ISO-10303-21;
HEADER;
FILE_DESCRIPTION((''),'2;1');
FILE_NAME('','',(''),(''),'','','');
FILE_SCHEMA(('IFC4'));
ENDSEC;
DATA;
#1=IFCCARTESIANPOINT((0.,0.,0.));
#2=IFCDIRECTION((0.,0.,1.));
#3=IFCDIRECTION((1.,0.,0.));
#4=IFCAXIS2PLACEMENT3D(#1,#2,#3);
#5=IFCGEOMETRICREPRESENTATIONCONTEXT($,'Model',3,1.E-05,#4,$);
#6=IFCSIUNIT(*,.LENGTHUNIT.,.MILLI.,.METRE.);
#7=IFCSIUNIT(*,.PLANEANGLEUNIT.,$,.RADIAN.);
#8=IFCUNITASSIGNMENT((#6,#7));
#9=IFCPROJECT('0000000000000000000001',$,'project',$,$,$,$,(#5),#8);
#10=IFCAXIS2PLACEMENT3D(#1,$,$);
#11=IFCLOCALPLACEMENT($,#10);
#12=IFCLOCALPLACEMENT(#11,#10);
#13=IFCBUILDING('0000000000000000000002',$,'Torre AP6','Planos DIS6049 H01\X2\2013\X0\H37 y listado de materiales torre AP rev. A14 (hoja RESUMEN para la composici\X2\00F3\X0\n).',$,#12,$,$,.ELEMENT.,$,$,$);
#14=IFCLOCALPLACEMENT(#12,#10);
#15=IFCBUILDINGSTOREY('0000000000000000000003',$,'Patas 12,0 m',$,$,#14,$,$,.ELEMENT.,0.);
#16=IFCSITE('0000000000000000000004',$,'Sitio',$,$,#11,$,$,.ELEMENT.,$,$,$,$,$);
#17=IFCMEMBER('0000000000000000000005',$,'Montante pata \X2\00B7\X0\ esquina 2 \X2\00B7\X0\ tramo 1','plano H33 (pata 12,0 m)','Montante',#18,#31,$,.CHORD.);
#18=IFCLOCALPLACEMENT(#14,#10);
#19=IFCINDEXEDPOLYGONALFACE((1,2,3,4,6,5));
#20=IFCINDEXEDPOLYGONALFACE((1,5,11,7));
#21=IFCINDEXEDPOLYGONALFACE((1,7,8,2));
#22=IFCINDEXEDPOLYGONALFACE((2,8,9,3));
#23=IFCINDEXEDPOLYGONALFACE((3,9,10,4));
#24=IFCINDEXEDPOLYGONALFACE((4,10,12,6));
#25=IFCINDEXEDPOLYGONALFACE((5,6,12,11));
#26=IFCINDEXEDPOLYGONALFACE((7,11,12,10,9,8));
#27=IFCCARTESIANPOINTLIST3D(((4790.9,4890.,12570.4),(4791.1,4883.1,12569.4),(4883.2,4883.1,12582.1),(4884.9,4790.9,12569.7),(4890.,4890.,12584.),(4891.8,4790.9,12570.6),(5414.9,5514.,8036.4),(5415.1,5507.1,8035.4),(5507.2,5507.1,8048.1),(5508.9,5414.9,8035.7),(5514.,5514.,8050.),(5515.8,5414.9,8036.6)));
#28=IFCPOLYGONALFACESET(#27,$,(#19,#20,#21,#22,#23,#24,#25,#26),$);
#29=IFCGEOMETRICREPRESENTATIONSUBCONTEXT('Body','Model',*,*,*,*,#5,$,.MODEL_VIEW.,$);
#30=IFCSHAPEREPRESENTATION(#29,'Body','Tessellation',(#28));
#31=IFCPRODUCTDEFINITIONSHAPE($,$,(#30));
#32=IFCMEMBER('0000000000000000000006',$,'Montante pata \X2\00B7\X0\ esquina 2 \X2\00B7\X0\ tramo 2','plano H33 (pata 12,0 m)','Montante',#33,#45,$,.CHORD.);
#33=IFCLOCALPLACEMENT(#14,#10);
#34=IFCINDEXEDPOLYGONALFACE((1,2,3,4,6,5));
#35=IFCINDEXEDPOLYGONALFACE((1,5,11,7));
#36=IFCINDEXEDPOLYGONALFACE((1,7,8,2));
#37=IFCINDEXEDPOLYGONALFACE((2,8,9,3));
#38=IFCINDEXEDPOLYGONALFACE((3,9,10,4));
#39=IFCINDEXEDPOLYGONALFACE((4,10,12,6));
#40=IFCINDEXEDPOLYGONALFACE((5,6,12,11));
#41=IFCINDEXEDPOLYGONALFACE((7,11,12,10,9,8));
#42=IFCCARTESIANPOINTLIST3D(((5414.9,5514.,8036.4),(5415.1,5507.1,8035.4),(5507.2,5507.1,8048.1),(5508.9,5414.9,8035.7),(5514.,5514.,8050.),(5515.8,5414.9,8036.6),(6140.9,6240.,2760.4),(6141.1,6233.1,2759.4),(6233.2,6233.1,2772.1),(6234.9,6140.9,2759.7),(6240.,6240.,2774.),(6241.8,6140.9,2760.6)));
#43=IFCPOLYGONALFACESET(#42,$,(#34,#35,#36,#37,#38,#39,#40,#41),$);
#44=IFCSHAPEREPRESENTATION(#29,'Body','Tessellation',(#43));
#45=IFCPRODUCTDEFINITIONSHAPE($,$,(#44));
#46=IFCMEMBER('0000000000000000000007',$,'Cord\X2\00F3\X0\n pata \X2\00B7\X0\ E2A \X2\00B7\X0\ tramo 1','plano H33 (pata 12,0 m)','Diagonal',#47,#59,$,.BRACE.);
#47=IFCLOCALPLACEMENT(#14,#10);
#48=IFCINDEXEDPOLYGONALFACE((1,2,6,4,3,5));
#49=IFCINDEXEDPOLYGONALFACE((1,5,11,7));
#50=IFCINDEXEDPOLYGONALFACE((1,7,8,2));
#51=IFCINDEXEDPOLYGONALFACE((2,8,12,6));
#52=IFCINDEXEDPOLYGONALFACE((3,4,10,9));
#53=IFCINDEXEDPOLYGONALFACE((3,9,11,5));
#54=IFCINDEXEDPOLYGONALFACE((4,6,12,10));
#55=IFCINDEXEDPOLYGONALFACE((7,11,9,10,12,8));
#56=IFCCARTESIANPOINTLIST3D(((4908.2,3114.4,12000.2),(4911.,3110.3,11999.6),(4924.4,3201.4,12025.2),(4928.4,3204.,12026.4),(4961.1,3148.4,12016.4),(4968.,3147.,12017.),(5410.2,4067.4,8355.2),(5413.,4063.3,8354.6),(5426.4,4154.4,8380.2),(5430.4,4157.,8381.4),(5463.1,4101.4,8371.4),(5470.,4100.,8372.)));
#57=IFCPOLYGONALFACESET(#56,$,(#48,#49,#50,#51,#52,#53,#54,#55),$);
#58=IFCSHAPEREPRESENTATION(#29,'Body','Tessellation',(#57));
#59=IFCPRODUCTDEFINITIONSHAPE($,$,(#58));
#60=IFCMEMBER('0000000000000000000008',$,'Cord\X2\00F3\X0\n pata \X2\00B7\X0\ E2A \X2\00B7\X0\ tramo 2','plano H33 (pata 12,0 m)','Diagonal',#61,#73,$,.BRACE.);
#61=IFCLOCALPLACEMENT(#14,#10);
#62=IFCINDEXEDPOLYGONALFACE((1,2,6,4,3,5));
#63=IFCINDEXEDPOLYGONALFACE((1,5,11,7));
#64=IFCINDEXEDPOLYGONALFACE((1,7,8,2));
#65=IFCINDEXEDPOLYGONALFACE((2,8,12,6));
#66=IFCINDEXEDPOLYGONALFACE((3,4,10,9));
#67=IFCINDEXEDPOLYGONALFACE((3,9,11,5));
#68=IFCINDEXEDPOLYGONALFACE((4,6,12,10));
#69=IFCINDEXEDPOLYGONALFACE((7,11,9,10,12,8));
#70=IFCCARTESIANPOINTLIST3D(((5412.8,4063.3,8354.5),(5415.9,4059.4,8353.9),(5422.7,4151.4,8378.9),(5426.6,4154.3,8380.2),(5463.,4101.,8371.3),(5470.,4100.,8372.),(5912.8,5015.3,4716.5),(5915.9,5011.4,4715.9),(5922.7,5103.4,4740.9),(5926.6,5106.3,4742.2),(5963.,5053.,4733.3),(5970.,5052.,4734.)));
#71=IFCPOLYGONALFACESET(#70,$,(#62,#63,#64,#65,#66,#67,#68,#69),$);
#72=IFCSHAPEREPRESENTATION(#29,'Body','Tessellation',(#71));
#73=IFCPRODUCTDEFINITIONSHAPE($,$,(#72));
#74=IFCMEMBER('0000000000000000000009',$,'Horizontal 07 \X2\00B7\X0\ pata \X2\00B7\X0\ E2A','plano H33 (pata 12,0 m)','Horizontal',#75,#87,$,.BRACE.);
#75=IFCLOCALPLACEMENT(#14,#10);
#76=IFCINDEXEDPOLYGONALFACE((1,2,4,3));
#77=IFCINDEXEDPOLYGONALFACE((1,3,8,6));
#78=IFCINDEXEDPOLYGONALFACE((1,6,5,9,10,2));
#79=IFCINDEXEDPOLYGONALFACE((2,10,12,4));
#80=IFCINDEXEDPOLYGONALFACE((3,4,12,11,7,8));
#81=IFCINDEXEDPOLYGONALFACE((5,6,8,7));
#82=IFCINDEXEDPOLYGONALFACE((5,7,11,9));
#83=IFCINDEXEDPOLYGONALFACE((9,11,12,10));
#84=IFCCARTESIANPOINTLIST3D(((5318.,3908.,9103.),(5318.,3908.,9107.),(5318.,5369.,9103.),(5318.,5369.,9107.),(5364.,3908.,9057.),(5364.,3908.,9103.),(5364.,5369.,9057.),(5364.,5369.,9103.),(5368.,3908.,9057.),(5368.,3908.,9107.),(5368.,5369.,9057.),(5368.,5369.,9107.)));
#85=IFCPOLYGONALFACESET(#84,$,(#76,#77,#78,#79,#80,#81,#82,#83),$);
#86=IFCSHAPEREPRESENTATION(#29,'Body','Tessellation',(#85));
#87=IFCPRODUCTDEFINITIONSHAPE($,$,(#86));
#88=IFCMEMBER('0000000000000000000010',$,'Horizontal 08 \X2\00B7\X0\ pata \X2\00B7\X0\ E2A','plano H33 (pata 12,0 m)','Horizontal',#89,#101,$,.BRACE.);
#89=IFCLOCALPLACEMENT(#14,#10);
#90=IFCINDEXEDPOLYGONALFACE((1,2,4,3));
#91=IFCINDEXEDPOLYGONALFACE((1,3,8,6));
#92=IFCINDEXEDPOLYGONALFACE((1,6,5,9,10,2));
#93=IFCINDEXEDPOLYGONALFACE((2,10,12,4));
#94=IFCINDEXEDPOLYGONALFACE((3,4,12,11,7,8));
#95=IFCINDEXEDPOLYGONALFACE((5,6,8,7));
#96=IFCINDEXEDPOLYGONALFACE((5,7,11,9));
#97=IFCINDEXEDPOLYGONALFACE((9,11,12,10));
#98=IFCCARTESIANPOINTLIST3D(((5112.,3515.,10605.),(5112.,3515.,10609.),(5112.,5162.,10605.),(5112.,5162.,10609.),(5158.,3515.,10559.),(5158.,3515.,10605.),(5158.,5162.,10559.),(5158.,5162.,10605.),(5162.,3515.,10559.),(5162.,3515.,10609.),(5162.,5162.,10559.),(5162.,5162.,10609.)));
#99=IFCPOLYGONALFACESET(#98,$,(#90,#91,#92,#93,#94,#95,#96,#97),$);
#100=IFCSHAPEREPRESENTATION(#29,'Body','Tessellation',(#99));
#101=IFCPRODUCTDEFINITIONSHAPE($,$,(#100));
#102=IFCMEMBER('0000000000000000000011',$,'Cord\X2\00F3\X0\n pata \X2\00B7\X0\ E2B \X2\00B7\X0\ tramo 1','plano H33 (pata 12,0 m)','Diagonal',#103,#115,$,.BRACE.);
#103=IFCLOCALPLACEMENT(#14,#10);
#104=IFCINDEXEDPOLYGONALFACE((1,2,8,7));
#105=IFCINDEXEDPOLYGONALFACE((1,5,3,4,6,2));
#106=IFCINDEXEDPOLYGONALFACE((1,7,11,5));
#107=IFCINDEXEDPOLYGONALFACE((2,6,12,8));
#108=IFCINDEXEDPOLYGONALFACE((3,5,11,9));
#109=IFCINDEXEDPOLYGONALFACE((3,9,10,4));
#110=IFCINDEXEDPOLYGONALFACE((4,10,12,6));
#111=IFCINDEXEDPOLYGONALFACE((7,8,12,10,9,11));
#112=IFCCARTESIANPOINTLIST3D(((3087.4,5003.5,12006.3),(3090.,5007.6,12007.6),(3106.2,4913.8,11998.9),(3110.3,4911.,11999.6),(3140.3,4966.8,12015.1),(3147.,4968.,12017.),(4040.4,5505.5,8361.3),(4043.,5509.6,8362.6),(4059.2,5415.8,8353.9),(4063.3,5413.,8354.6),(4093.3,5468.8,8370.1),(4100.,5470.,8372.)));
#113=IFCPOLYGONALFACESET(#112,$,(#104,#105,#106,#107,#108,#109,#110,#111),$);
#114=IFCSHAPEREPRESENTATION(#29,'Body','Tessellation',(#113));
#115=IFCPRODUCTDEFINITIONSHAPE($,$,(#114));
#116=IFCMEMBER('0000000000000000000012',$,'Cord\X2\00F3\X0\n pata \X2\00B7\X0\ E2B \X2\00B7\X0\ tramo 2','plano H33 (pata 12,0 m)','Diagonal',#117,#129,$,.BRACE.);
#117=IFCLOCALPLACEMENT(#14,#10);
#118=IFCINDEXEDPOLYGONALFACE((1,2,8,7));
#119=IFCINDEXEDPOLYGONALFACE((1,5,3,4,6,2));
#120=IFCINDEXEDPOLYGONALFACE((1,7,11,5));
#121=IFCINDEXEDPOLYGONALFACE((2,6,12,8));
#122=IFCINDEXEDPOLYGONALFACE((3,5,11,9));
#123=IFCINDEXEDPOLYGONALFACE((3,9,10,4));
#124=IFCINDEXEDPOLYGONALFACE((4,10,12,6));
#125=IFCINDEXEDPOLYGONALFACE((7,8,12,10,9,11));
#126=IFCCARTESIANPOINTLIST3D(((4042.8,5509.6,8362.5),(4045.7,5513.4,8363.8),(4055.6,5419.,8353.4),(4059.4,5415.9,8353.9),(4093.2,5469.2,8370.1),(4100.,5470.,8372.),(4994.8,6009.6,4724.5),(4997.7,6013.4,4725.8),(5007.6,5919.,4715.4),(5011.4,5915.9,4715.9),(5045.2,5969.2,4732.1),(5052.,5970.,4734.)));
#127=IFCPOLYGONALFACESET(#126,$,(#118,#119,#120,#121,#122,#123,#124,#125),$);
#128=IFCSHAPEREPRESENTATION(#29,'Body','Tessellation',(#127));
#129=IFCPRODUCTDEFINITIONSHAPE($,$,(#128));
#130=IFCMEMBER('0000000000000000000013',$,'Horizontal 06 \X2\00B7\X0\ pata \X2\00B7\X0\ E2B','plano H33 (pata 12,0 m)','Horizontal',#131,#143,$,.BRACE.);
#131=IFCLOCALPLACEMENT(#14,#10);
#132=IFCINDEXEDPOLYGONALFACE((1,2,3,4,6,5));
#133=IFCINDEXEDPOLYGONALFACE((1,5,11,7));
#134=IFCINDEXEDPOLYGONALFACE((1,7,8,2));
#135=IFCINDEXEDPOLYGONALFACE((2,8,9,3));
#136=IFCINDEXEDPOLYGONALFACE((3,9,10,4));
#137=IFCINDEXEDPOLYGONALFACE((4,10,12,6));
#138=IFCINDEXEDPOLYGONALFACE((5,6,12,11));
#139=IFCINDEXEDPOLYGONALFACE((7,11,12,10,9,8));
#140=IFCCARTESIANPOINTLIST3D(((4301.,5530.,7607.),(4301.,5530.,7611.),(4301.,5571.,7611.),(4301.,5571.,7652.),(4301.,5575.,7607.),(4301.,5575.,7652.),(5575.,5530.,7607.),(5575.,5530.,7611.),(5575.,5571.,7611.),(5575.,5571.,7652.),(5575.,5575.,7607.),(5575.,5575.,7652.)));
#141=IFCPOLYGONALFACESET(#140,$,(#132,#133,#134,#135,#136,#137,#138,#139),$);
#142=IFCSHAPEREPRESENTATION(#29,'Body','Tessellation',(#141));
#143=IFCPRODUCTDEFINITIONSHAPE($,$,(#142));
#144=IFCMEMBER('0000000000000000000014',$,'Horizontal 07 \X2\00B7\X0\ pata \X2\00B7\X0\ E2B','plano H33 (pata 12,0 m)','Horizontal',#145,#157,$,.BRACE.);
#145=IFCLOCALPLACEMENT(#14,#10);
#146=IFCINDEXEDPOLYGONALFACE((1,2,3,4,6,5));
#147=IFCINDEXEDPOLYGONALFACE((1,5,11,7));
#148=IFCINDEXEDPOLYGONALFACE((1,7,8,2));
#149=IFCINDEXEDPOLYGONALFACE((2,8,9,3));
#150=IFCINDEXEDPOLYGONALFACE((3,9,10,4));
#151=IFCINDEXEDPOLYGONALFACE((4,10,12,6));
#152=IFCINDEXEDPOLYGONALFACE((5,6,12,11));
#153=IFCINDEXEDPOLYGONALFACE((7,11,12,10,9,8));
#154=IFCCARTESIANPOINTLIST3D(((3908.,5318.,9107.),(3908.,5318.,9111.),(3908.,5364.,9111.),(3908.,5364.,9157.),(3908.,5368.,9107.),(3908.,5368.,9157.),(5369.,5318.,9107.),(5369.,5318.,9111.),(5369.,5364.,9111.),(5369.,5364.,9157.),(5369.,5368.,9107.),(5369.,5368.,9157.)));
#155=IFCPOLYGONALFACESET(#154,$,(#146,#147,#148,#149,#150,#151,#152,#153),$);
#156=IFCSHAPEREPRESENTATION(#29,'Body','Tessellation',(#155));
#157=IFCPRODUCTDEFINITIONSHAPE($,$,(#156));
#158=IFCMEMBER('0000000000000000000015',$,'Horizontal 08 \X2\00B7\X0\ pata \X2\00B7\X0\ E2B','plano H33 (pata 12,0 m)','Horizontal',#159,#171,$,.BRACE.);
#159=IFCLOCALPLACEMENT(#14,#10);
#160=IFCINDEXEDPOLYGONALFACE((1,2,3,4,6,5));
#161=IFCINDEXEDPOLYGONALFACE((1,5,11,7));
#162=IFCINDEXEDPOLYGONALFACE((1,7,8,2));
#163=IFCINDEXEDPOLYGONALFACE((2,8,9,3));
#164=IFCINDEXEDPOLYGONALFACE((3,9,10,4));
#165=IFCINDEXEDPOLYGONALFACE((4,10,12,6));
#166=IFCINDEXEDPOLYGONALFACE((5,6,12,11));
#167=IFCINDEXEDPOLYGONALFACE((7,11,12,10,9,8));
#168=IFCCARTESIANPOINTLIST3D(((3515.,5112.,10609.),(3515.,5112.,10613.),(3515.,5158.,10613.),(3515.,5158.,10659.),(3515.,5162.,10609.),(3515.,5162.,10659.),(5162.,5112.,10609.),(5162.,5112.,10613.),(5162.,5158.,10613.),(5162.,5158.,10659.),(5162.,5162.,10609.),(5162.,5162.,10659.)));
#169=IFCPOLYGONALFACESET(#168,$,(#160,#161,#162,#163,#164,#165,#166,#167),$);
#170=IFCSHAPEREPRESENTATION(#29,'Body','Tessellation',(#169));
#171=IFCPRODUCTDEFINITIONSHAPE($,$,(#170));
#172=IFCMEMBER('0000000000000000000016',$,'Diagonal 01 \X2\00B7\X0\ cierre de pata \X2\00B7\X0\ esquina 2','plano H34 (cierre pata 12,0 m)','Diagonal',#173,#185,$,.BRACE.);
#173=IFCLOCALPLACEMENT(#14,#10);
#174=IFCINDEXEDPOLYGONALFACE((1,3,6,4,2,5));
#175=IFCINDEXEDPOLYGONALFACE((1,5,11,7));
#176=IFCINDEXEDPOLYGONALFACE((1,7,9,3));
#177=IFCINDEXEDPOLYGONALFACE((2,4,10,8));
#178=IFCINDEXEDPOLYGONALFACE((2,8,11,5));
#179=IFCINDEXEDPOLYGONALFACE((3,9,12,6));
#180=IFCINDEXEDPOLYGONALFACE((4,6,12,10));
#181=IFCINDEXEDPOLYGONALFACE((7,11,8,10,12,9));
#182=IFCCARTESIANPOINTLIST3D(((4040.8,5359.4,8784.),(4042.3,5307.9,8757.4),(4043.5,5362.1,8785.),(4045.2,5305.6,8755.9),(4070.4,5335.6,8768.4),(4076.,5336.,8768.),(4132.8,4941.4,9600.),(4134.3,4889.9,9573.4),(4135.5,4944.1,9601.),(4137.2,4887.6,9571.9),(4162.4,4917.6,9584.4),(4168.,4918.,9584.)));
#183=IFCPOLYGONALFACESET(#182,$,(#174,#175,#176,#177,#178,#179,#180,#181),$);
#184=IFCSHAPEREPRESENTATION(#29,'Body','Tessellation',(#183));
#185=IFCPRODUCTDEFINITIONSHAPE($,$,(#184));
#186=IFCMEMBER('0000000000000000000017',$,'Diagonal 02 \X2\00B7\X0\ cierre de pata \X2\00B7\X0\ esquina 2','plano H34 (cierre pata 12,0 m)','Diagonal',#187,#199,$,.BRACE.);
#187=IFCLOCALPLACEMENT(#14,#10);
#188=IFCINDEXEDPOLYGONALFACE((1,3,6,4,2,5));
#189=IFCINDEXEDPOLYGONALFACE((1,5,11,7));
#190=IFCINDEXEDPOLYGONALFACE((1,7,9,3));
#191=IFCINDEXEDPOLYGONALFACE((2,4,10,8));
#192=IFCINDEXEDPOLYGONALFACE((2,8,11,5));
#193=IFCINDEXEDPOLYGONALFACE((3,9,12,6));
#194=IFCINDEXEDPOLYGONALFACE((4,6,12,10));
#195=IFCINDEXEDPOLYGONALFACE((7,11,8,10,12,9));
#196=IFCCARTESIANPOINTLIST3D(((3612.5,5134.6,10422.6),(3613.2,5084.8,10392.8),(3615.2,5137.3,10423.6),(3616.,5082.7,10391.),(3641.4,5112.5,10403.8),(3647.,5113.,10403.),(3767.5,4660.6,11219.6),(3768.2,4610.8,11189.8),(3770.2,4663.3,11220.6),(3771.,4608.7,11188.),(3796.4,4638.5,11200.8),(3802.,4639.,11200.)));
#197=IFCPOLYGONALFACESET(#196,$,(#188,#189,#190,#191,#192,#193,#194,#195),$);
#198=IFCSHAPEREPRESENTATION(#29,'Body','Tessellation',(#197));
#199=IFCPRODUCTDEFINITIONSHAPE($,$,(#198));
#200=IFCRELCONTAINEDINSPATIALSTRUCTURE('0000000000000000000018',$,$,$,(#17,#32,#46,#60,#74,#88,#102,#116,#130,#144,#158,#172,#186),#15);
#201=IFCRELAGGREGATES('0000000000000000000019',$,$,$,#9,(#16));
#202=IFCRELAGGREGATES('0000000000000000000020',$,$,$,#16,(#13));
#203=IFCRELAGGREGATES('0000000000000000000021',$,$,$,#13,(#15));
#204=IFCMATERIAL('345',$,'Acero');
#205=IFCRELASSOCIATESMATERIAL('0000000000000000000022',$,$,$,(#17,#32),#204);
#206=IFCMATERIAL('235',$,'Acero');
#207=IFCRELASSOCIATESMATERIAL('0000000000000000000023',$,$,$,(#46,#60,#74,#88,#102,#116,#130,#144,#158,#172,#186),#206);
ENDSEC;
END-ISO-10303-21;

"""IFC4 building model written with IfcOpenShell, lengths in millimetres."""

from ifc_helpers import new_model, si_unit, frame, frame_2d, origin, origin_with_axes, place, context, subcontext, project, spatial, l_section, extrude, material, element, save


model = new_model("IFC4")

# Units and contexts
model_context = context("Model", 3, precision=1e-05, world=origin_with_axes())
body_context = subcontext(model_context, "Body", "Model", "MODEL_VIEW")
ifc_project = project(units=[si_unit("LENGTHUNIT", "METRE", prefix="MILLI"), si_unit("PLANEANGLEUNIT", "RADIAN")], contexts=[model_context])

# Site, building, storey
site_placement = place(None, origin())
site = spatial("IfcSite", under=ifc_project, at=site_placement, Name="Sitio", CompositionType="ELEMENT")
building_placement = place(site_placement, origin())
building = spatial("IfcBuilding", under=site, at=building_placement, Name="Torre AP6", Description="Planos DIS6049 H01–H37 y listado de materiales torre AP rev. A14 (hoja RESUMEN para la composición).", CompositionType="ELEMENT")
storey_placement = place(building_placement, origin())
storey = spatial("IfcBuildingStorey", under=building, at=storey_placement, Name="Patas 12,0 m", CompositionType="ELEMENT", Elevation=0.0)

# Members
ifc_material_1 = material(Name="345", Category="Acero")
member_1_placement = place(storey_placement, frame((4890.0, 4890.0, 12584.0), z_axis=(0.135092, 0.135092, -0.981581), x_axis=(0.018419, -0.990833, -0.13383)))
element("IfcMember", 1, at=member_1_placement, inside=storey, material=ifc_material_1, Name="Montante pata · esquina 2 · tramo 1", Description="plano H33 (pata 12,0 m)", ObjectType="Montante", PredefinedType="CHORD", context=body_context, shape_type="SweptSolid", body=[
    extrude(l_section(Depth=100.0, Width=100.0, Thickness=7.0, at=frame_2d((50.0, 50.0))), None, (0.0, 0.0, 1.0), 4619.1),
])
member_2_placement = place(storey_placement, frame((5514.0, 5514.0, 8050.0), z_axis=(0.13507, 0.13507, -0.981586), x_axis=(0.018413, -0.990836, -0.13381)))
element("IfcMember", 2, at=member_2_placement, inside=storey, material=ifc_material_1, Name="Montante pata · esquina 2 · tramo 2", Description="plano H33 (pata 12,0 m)", ObjectType="Montante", PredefinedType="CHORD", context=body_context, shape_type="SweptSolid", body=[
    extrude(l_section(Depth=100.0, Width=100.0, Thickness=7.0, at=frame_2d((50.0, 50.0))), None, (0.0, 0.0, 1.0), 5375.0),
])
ifc_material_2 = material(Name="235", Category="Acero")
member_3_placement = place(storey_placement, frame((4968.0, 3147.0, 12017.0), z_axis=(0.132077, 0.250735, -0.959003), x_axis=(-0.814388, -0.524098, -0.249187)))
element("IfcMember", 3, at=member_3_placement, inside=storey, material=ifc_material_2, Name="Cordón pata · E2A · tramo 1", Description="plano H33 (pata 12,0 m)", ObjectType="Diagonal", PredefinedType="BRACE", context=body_context, shape_type="SweptSolid", body=[
    extrude(l_section(Depth=70.0, Width=70.0, Thickness=5.0, at=frame_2d((35.0, 35.0))), None, (0.0, 0.0, 1.0), 3800.8),
])
member_4_placement = place(storey_placement, frame((5470.0, 4100.0, 8372.0), z_axis=(0.131801, 0.250949, -0.958985), x_axis=(-0.773167, -0.579405, -0.257883)))
element("IfcMember", 4, at=member_4_placement, inside=storey, material=ifc_material_2, Name="Cordón pata · E2A · tramo 2", Description="plano H33 (pata 12,0 m)", ObjectType="Diagonal", PredefinedType="BRACE", context=body_context, shape_type="SweptSolid", body=[
    extrude(l_section(Depth=70.0, Width=70.0, Thickness=5.0, at=frame_2d((35.0, 35.0))), None, (0.0, 0.0, 1.0), 3793.6),
])
member_5_placement = place(storey_placement, frame((5368.0, 5369.0, 9107.0), z_axis=(0.0, -1.0, 0.0), x_axis=(-1.0, 0.0, 0.0)))
element("IfcMember", 5, at=member_5_placement, inside=storey, material=ifc_material_2, Name="Horizontal 07 · pata · E2A", Description="plano H33 (pata 12,0 m)", ObjectType="Horizontal", PredefinedType="BRACE", context=body_context, shape_type="SweptSolid", body=[
    extrude(l_section(Depth=50.0, Width=50.0, Thickness=4.0, at=frame_2d((25.0, 25.0))), None, (0.0, 0.0, 1.0), 1461.0),
])
member_6_placement = place(storey_placement, frame((5162.0, 5162.0, 10609.0), z_axis=(0.0, -1.0, 0.0), x_axis=(-1.0, 0.0, 0.0)))
element("IfcMember", 6, at=member_6_placement, inside=storey, material=ifc_material_2, Name="Horizontal 08 · pata · E2A", Description="plano H33 (pata 12,0 m)", ObjectType="Horizontal", PredefinedType="BRACE", context=body_context, shape_type="SweptSolid", body=[
    extrude(l_section(Depth=50.0, Width=50.0, Thickness=4.0, at=frame_2d((25.0, 25.0))), None, (0.0, 0.0, 1.0), 1647.0),
])
member_7_placement = place(storey_placement, frame((3147.0, 4968.0, 12017.0), z_axis=(0.250735, 0.132077, -0.959003), x_axis=(-0.524098, -0.814388, -0.249187)))
element("IfcMember", 7, at=member_7_placement, inside=storey, material=ifc_material_2, Name="Cordón pata · E2B · tramo 1", Description="plano H33 (pata 12,0 m)", ObjectType="Diagonal", PredefinedType="BRACE", context=body_context, shape_type="SweptSolid", body=[
    extrude(l_section(Depth=70.0, Width=70.0, Thickness=5.0, at=frame_2d((35.0, 35.0))), None, (0.0, 0.0, 1.0), 3800.8),
])
member_8_placement = place(storey_placement, frame((4100.0, 5470.0, 8372.0), z_axis=(0.250949, 0.131801, -0.958985), x_axis=(-0.579405, -0.773167, -0.257883)))
element("IfcMember", 8, at=member_8_placement, inside=storey, material=ifc_material_2, Name="Cordón pata · E2B · tramo 2", Description="plano H33 (pata 12,0 m)", ObjectType="Diagonal", PredefinedType="BRACE", context=body_context, shape_type="SweptSolid", body=[
    extrude(l_section(Depth=70.0, Width=70.0, Thickness=5.0, at=frame_2d((35.0, 35.0))), None, (0.0, 0.0, 1.0), 3793.6),
])
member_9_placement = place(storey_placement, frame((5575.0, 5575.0, 7607.0), z_axis=(-1.0, 0.0, 0.0), x_axis=(0.0, -1.0, 0.0)))
element("IfcMember", 9, at=member_9_placement, inside=storey, material=ifc_material_2, Name="Horizontal 06 · pata · E2B", Description="plano H33 (pata 12,0 m)", ObjectType="Horizontal", PredefinedType="BRACE", context=body_context, shape_type="SweptSolid", body=[
    extrude(l_section(Depth=45.0, Width=45.0, Thickness=4.0, at=frame_2d((22.5, 22.5))), None, (0.0, 0.0, 1.0), 1274.0),
])
member_10_placement = place(storey_placement, frame((5369.0, 5368.0, 9107.0), z_axis=(-1.0, 0.0, 0.0), x_axis=(0.0, -1.0, 0.0)))
element("IfcMember", 10, at=member_10_placement, inside=storey, material=ifc_material_2, Name="Horizontal 07 · pata · E2B", Description="plano H33 (pata 12,0 m)", ObjectType="Horizontal", PredefinedType="BRACE", context=body_context, shape_type="SweptSolid", body=[
    extrude(l_section(Depth=50.0, Width=50.0, Thickness=4.0, at=frame_2d((25.0, 25.0))), None, (0.0, 0.0, 1.0), 1461.0),
])
member_11_placement = place(storey_placement, frame((5162.0, 5162.0, 10609.0), z_axis=(-1.0, 0.0, 0.0), x_axis=(0.0, -1.0, 0.0)))
element("IfcMember", 11, at=member_11_placement, inside=storey, material=ifc_material_2, Name="Horizontal 08 · pata · E2B", Description="plano H33 (pata 12,0 m)", ObjectType="Horizontal", PredefinedType="BRACE", context=body_context, shape_type="SweptSolid", body=[
    extrude(l_section(Depth=50.0, Width=50.0, Thickness=4.0, at=frame_2d((25.0, 25.0))), None, (0.0, 0.0, 1.0), 1647.0),
])
member_12_placement = place(storey_placement, frame((4168.0, 4918.0, 9584.0), z_axis=(-0.099844, 0.45364, -0.885574), x_axis=(-0.685291, -0.676631, -0.269344)))
element("IfcMember", 12, at=member_12_placement, inside=storey, material=ifc_material_2, Name="Diagonal 01 · cierre de pata · esquina 2", Description="plano H34 (cierre pata 12,0 m)", ObjectType="Diagonal", PredefinedType="BRACE", context=body_context, shape_type="SweptSolid", body=[
    extrude(l_section(Depth=45.0, Width=45.0, Thickness=4.0, at=frame_2d((22.5, 22.5))), None, (0.0, 0.0, 1.0), 921.4),
])
member_13_placement = place(storey_placement, frame((3802.0, 4639.0, 11200.0), z_axis=(-0.164865, 0.504167, -0.847724), x_axis=(-0.688407, -0.674329, -0.267163)))
element("IfcMember", 13, at=member_13_placement, inside=storey, material=ifc_material_2, Name="Diagonal 02 · cierre de pata · esquina 2", Description="plano H34 (cierre pata 12,0 m)", ObjectType="Diagonal", PredefinedType="BRACE", context=body_context, shape_type="SweptSolid", body=[
    extrude(l_section(Depth=45.0, Width=45.0, Thickness=4.0, at=frame_2d((22.5, 22.5))), None, (0.0, 0.0, 1.0), 940.2),
])

save(model, "model.ifc")
